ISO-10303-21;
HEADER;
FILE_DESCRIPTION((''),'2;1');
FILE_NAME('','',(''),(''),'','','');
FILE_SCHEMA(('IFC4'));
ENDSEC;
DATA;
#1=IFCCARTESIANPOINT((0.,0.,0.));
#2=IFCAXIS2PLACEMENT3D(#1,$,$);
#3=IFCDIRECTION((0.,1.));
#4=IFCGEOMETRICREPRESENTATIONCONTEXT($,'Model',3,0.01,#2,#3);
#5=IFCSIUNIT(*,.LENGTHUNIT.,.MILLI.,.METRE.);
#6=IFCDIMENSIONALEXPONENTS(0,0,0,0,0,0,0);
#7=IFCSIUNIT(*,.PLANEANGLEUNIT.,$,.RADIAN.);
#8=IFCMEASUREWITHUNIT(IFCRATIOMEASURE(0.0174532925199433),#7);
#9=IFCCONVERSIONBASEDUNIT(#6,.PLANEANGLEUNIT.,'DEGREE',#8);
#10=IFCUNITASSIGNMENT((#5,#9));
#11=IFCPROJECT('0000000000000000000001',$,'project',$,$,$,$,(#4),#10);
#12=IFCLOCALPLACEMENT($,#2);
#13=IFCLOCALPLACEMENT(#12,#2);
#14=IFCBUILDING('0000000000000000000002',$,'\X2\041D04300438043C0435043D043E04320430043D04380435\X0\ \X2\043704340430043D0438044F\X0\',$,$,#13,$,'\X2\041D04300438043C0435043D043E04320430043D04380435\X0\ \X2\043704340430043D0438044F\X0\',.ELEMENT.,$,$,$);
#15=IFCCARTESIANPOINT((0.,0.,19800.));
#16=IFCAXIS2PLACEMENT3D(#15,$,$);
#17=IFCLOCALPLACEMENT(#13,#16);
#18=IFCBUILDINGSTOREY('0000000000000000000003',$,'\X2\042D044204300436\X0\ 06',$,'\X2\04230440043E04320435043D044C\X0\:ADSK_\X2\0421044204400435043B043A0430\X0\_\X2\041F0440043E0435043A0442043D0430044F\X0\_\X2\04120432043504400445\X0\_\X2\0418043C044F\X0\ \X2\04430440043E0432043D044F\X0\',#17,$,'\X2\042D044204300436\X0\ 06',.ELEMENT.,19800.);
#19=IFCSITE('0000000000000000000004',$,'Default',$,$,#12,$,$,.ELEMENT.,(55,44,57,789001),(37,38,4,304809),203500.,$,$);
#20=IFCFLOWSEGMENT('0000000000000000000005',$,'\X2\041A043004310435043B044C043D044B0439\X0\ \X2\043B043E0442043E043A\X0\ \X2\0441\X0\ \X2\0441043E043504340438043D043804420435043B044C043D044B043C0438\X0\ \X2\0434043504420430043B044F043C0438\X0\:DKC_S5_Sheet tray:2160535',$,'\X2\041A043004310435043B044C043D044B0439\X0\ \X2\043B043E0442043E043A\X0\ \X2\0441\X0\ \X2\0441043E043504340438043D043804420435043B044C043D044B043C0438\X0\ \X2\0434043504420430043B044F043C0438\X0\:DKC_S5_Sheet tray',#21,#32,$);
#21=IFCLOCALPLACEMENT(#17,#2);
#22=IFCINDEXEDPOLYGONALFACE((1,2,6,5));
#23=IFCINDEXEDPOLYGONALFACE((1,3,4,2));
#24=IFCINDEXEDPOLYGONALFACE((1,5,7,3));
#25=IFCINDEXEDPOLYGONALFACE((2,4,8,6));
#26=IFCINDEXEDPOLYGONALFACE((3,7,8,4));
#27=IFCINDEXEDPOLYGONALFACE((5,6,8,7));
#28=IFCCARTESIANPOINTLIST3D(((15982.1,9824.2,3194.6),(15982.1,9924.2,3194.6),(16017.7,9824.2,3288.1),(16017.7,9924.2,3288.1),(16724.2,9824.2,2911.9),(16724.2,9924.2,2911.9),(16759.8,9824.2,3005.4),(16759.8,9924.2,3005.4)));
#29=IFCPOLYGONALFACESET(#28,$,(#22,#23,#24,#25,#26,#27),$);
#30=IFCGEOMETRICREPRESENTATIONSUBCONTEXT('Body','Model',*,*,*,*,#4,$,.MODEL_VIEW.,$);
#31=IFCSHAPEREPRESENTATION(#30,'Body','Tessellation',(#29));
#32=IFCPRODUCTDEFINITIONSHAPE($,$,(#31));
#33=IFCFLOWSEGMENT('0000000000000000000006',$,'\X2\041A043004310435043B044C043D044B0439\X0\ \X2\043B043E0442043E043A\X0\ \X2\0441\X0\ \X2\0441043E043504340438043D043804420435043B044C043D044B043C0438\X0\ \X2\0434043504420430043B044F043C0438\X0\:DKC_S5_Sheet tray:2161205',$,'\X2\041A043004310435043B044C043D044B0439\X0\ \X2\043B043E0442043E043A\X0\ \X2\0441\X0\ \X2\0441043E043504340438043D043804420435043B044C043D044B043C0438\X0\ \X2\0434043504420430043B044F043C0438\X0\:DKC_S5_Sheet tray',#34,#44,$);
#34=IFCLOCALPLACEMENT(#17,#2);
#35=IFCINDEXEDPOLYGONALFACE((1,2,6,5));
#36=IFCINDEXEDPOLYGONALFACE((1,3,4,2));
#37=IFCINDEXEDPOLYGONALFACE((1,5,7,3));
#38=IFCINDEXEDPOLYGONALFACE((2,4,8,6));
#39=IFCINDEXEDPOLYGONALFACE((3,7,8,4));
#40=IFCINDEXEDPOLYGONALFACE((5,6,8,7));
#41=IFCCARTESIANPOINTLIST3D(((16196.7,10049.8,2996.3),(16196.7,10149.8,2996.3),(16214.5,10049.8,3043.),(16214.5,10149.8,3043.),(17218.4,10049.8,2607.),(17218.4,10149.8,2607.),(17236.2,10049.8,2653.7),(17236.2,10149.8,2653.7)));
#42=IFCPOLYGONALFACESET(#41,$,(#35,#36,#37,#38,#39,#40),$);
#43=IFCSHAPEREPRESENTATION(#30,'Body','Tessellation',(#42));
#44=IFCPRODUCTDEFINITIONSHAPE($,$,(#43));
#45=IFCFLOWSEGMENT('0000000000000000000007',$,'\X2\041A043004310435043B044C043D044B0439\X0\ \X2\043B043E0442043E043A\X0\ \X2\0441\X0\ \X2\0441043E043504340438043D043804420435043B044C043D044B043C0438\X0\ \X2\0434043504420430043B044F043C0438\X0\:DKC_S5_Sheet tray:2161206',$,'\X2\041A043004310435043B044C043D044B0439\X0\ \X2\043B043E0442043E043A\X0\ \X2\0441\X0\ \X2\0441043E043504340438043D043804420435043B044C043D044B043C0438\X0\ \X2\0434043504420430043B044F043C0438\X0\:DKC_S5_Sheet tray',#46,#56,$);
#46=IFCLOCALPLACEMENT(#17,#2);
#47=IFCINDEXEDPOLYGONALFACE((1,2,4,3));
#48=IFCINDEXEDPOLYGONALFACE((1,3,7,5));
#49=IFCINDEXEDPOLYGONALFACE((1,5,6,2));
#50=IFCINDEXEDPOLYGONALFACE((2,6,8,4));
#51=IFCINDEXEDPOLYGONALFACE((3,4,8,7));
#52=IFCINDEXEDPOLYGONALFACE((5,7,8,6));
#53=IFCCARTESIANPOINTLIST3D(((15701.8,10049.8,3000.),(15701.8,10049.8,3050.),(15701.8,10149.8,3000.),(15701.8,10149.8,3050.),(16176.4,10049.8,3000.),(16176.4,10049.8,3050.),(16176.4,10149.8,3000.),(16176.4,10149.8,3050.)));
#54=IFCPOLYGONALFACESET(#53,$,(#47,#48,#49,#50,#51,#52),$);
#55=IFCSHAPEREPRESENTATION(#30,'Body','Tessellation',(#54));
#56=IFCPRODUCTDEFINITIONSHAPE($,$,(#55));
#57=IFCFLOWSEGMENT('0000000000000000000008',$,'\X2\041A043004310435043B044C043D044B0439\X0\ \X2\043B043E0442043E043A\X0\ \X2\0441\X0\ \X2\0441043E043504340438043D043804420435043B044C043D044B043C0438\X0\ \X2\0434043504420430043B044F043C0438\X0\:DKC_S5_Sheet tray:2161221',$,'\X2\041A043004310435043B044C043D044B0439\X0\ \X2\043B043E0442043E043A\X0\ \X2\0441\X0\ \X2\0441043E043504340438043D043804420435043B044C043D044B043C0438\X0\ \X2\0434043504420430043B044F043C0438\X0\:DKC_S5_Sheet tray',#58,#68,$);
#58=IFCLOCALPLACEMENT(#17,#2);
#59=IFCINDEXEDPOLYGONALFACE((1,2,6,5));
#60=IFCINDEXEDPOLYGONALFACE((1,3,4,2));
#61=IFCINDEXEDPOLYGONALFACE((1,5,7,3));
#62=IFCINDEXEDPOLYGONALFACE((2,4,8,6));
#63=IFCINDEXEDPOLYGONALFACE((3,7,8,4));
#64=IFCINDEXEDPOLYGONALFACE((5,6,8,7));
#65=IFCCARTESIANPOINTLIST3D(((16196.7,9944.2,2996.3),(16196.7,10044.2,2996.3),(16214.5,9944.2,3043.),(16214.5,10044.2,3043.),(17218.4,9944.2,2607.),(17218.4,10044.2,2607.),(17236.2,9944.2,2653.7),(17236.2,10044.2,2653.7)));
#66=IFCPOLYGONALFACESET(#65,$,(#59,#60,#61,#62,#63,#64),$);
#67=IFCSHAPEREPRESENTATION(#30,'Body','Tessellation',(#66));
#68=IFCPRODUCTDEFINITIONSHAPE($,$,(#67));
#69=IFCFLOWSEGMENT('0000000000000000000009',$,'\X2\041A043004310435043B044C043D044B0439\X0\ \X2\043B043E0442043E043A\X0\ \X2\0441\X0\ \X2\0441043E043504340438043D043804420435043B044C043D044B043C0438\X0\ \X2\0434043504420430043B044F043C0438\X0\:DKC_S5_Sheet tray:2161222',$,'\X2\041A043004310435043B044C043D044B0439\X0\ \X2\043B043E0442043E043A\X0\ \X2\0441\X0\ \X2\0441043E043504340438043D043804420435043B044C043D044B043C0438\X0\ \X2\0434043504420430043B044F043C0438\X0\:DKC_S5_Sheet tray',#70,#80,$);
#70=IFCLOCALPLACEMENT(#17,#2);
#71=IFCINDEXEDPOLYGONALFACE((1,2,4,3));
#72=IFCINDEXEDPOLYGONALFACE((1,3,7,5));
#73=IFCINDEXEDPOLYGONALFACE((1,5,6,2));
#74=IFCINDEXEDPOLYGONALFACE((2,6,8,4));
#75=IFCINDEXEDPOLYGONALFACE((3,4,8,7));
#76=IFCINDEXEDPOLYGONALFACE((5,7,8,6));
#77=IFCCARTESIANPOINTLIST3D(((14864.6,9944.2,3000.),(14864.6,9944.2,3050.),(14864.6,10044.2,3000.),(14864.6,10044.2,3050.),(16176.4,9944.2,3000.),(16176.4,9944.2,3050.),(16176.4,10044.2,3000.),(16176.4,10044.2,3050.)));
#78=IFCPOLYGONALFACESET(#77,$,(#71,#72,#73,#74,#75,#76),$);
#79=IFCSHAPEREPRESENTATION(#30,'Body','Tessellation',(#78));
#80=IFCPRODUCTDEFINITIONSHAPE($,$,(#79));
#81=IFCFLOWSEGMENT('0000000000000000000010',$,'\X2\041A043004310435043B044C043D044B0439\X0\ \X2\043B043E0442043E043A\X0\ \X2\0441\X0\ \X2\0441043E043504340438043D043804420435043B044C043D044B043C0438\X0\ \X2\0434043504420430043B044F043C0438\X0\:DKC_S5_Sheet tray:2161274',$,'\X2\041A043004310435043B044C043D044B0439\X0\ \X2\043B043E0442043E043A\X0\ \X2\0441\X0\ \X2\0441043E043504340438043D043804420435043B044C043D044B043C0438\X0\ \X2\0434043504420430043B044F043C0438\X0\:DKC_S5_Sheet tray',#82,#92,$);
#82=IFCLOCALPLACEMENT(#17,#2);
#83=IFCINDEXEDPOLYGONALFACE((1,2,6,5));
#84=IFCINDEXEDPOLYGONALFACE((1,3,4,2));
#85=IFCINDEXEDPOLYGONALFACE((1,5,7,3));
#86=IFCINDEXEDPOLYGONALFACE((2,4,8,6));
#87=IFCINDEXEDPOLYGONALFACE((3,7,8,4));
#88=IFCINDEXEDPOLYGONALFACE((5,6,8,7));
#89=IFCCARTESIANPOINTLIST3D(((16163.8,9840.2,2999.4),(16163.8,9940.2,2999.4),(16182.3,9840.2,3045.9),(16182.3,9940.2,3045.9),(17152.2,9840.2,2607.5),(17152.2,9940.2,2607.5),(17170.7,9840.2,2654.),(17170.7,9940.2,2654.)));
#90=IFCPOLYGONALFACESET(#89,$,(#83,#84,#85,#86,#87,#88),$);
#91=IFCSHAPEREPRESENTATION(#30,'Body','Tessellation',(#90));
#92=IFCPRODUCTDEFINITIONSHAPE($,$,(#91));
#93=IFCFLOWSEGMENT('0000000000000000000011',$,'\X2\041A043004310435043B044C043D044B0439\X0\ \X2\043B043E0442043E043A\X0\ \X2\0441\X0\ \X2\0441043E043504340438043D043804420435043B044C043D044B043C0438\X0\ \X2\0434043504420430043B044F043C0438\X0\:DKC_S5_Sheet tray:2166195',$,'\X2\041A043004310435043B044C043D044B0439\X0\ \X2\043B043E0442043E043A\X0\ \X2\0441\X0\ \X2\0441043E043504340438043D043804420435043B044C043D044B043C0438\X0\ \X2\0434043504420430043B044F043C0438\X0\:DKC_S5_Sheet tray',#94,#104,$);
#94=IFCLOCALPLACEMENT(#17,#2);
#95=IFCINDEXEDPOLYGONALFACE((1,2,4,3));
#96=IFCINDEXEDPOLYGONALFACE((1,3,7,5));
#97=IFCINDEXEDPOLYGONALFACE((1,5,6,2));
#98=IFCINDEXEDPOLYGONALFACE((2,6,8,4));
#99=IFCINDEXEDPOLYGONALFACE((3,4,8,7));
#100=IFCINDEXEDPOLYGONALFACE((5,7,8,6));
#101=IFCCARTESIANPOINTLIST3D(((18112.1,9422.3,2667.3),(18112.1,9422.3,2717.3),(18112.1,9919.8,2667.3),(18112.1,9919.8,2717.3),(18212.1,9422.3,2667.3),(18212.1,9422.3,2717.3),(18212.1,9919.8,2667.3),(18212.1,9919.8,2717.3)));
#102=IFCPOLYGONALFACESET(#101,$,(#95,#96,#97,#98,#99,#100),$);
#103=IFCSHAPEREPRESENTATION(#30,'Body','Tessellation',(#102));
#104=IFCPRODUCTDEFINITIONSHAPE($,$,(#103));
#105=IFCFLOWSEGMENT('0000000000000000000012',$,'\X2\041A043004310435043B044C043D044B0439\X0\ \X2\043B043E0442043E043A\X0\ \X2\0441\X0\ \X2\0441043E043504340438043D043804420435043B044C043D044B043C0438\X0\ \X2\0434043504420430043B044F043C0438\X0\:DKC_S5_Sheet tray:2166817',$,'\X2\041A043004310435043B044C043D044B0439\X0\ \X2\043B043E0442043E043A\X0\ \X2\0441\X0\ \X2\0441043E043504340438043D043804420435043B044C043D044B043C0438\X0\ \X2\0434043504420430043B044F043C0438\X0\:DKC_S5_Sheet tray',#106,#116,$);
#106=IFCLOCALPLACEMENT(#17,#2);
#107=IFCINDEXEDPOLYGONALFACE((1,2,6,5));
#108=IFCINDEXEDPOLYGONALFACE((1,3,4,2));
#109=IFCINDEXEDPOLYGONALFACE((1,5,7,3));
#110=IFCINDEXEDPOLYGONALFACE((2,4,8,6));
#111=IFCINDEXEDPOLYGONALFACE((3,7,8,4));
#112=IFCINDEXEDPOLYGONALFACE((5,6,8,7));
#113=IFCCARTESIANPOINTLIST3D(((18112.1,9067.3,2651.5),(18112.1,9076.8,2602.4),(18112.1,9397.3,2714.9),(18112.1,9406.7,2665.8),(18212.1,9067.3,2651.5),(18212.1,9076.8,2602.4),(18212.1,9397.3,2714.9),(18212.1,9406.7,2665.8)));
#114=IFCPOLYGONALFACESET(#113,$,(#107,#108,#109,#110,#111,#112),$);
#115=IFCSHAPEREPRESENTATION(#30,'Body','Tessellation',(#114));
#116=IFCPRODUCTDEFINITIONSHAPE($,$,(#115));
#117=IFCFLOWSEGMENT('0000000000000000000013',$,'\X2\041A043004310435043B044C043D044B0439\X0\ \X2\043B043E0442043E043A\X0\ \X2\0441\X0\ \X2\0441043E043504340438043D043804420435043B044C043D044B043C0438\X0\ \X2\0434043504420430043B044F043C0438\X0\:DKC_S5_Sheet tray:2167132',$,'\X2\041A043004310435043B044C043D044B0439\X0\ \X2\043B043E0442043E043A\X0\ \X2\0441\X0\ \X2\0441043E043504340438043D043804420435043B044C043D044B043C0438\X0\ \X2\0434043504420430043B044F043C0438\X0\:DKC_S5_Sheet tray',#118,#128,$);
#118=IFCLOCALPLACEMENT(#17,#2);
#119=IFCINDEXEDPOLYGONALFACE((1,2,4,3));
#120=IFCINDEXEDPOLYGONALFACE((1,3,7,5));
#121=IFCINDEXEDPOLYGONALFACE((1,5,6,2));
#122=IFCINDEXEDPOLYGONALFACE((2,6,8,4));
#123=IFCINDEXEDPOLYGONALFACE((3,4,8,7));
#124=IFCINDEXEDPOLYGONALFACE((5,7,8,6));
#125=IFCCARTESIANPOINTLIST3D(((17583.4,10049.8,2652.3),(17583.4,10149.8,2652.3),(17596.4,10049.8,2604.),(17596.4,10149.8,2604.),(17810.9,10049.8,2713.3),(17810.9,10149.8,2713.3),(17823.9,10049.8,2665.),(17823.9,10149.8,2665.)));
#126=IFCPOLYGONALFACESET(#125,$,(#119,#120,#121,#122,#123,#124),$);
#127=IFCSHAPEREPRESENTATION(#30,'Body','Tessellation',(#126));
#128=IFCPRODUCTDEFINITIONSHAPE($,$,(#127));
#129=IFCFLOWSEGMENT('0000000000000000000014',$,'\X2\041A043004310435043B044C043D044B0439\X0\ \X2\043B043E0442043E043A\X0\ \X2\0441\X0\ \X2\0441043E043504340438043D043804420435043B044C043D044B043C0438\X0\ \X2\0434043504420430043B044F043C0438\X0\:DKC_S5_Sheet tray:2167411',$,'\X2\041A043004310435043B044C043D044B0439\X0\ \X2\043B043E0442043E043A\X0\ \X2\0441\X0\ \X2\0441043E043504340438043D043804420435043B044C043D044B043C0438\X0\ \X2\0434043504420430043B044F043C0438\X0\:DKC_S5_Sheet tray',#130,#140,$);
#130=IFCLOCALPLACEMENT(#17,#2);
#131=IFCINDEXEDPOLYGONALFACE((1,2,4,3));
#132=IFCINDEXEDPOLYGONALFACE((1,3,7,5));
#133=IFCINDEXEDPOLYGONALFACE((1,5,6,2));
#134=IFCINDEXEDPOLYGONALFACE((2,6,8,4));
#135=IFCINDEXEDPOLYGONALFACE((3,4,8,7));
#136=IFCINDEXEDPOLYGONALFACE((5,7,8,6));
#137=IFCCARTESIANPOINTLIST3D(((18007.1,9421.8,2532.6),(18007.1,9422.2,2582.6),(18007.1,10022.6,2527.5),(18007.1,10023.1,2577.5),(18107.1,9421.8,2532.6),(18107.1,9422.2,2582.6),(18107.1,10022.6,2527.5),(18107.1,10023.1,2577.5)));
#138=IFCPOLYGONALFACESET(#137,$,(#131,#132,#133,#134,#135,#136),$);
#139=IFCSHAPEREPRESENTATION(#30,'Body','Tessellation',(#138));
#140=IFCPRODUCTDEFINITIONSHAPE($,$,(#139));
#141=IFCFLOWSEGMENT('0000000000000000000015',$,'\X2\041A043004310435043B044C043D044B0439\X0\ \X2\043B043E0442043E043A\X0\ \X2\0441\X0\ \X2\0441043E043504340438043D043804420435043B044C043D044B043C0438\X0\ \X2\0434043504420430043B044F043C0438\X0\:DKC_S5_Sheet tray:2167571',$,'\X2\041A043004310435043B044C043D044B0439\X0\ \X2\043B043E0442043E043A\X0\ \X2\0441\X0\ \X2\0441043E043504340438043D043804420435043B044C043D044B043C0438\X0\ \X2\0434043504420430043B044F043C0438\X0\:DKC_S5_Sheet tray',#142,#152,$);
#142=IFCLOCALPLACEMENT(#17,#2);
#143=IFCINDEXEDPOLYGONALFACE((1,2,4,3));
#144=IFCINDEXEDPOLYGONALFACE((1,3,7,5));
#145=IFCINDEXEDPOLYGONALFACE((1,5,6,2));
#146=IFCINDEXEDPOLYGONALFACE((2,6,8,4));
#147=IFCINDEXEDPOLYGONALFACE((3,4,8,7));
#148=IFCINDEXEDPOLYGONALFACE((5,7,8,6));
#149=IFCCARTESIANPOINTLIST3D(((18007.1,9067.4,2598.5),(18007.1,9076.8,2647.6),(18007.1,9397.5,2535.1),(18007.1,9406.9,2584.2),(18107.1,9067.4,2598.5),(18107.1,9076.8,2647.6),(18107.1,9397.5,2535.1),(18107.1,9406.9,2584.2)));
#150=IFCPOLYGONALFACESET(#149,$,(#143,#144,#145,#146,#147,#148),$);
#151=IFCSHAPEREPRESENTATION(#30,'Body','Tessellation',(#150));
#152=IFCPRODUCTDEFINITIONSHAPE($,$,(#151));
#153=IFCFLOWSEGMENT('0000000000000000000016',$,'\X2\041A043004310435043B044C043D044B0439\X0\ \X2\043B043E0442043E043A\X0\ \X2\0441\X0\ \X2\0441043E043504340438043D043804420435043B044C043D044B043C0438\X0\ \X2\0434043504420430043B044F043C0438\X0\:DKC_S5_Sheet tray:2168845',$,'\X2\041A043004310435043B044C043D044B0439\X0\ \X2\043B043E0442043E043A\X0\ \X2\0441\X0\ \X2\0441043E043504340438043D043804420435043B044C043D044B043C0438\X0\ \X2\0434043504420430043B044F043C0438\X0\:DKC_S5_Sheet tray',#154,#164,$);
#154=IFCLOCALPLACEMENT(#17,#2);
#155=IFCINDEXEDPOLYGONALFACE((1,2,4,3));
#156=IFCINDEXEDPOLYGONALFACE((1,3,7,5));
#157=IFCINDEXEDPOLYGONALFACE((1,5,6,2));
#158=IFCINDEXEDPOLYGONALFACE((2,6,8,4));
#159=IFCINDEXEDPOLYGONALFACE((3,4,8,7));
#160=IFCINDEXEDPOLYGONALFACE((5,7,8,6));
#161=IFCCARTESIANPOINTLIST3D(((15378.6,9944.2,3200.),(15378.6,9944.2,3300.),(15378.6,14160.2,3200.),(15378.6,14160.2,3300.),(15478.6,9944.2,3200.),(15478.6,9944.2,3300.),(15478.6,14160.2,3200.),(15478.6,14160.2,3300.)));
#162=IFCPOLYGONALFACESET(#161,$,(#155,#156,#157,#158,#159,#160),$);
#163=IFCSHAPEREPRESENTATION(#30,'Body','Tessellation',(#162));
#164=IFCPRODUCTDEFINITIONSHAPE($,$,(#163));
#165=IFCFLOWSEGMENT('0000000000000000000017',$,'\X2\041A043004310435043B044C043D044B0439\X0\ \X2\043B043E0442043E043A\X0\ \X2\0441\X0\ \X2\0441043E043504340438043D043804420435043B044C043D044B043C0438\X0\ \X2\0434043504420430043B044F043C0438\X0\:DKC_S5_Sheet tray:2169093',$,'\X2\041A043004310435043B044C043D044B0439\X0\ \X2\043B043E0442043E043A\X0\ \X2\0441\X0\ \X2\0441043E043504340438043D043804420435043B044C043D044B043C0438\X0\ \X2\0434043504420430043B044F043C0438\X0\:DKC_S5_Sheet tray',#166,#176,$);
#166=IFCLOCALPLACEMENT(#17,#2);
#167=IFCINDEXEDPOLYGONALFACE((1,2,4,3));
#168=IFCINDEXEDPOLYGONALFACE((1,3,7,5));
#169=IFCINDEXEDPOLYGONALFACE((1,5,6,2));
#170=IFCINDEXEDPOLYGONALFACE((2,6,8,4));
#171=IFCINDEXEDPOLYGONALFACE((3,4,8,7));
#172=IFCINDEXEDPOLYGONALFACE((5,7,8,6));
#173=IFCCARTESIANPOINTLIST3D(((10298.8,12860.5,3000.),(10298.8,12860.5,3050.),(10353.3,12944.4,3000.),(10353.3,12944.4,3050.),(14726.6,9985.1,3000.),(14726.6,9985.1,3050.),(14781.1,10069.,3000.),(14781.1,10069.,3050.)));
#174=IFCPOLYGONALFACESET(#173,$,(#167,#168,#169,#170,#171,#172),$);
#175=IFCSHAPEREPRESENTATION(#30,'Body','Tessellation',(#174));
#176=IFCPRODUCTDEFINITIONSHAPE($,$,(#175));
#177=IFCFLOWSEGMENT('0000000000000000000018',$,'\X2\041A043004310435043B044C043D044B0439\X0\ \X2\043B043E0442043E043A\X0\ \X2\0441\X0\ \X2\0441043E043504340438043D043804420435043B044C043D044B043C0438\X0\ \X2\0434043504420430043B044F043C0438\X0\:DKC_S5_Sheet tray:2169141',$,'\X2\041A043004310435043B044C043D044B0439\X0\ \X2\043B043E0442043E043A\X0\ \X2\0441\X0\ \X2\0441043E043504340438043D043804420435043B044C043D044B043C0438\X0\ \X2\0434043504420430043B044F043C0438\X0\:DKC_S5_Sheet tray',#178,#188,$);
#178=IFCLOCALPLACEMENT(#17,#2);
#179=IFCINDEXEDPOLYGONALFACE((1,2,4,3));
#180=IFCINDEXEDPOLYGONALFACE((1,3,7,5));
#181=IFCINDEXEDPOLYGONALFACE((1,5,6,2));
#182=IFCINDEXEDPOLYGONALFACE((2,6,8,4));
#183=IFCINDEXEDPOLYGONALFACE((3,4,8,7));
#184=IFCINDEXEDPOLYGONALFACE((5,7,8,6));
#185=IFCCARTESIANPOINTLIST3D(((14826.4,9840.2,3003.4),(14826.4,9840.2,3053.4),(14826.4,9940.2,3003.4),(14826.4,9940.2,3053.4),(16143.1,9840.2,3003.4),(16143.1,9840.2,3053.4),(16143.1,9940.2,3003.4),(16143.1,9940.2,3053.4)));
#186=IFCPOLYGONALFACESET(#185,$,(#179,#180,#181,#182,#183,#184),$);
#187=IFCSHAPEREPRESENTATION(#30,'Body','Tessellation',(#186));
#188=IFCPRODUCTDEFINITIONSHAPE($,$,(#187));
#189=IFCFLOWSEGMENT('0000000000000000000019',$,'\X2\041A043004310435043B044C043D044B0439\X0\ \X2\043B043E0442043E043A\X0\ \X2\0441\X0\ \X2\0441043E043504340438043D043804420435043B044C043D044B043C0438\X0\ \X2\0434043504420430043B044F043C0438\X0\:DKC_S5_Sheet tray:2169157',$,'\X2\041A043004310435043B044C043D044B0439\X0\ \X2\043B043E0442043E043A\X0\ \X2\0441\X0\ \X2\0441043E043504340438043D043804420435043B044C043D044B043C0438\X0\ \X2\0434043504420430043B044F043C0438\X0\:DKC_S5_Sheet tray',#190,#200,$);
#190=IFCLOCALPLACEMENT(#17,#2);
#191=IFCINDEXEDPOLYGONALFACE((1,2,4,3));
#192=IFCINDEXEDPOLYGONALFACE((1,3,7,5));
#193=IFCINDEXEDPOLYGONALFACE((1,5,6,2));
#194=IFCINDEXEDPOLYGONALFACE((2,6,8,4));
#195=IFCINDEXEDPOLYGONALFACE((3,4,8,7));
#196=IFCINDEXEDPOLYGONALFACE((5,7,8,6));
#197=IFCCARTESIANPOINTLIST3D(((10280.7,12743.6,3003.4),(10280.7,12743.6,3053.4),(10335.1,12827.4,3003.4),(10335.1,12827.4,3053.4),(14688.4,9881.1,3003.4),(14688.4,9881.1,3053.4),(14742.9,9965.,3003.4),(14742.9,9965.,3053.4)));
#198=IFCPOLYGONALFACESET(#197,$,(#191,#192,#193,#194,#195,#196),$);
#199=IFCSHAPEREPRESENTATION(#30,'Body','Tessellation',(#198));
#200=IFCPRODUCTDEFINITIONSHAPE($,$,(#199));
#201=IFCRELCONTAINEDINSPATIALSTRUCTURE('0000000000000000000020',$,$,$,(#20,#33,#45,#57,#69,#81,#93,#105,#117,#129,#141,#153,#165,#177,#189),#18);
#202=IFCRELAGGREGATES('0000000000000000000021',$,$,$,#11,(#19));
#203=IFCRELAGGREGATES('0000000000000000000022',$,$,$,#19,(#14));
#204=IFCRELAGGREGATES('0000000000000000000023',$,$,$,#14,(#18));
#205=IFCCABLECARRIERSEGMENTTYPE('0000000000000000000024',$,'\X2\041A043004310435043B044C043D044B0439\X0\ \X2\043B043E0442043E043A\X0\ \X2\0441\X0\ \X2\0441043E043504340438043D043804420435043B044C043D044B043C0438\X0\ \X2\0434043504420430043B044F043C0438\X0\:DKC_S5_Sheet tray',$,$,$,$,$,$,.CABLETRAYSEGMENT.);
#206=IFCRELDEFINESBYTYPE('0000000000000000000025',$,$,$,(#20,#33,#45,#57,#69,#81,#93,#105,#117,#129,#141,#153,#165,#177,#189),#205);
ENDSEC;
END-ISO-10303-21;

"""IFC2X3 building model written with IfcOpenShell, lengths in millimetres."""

from ifc_helpers import new_model, entity, si_unit, converted_unit, direction, frame, frame_2d, origin, origin_2d_with_axis, place, context, subcontext, project, spatial, rectangle, extrude, type_object, element, save


model = new_model("IFC2X3")

# Units and contexts
model_context = context("Model", 3, precision=0.01, world=origin(), true_north=direction((0.0, 1.0)))
body_context = subcontext(model_context, "Body", "Model", "MODEL_VIEW")
ifc_project = project(units=[si_unit("LENGTHUNIT", "METRE", prefix="MILLI"), converted_unit("PLANEANGLEUNIT", "DEGREE", entity("IfcRatioMeasure", 0.0174532925199433), si_unit("PLANEANGLEUNIT", "RADIAN"), dimensions=[0, 0, 0, 0, 0, 0, 0])], contexts=[model_context])

# Site, building, storey
site_placement = place(None, origin())
site = spatial("IfcSite", under=ifc_project, at=site_placement, Name="Default", CompositionType="ELEMENT", RefLatitude=(55, 44, 57, 789001), RefLongitude=(37, 38, 4, 304809), RefElevation=203500.0)
building_placement = place(site_placement, origin())
building = spatial("IfcBuilding", under=site, at=building_placement, Name="Наименование здания", LongName="Наименование здания", CompositionType="ELEMENT")
storey_placement = place(building_placement, frame((0.0, 0.0, 19800.0)))
storey = spatial("IfcBuildingStorey", under=building, at=storey_placement, Name="Этаж 06", ObjectType="Уровень:ADSK_Стрелка_Проектная_Вверх_Имя уровня", LongName="Этаж 06", CompositionType="ELEMENT", Elevation=19800.0)

# Flow segments
cable_carrier_segment_type = type_object("IfcCableCarrierSegmentType", Name="Кабельный лоток с соединительными деталями:DKC_S5_Sheet tray", PredefinedType="CABLETRAYSEGMENT")
flow_segment_1_placement = place(storey_placement, frame((15982.1, 9824.2, 2911.9)))
element("IfcFlowSegment", 1, at=flow_segment_1_placement, inside=storey, type_object=cable_carrier_segment_type, Name="Кабельный лоток с соединительными деталями:DKC_S5_Sheet tray:2160535", ObjectType="Кабельный лоток с соединительными деталями:DKC_S5_Sheet tray", context=body_context, shape_type="SweptSolid", body=[
    extrude(rectangle(XDim=100.0, YDim=100.0, at=origin_2d_with_axis()), frame((17.8, 50.0, 329.4), z_axis=(0.934483, 0.0, -0.356007), x_axis=(0.356007, 0.0, 0.934483)), (0.0, 0.0, 1.0), 794.0),
])
flow_segment_2_placement = place(storey_placement, frame((16196.7, 10049.8, 2607.0)))
element("IfcFlowSegment", 2, at=flow_segment_2_placement, inside=storey, type_object=cable_carrier_segment_type, Name="Кабельный лоток с соединительными деталями:DKC_S5_Sheet tray:2161205", ObjectType="Кабельный лоток с соединительными деталями:DKC_S5_Sheet tray", context=body_context, shape_type="SweptSolid", body=[
    extrude(rectangle(XDim=50.0, YDim=100.0, at=origin_2d_with_axis()), frame((8.9, 50.0, 412.6), z_axis=(0.934483, 0.0, -0.356007), x_axis=(0.356007, 0.0, 0.934483)), (0.0, 0.0, 1.0), 1093.3),
])
flow_segment_3_placement = place(storey_placement, frame((15701.8, 10049.8, 3000.0)))
element("IfcFlowSegment", 3, at=flow_segment_3_placement, inside=storey, type_object=cable_carrier_segment_type, Name="Кабельный лоток с соединительными деталями:DKC_S5_Sheet tray:2161206", ObjectType="Кабельный лоток с соединительными деталями:DKC_S5_Sheet tray", context=body_context, shape_type="SweptSolid", body=[
    extrude(rectangle(XDim=474.6, YDim=100.0, at=origin_2d_with_axis()), frame((237.3, 50.0, 0.0), z_axis=(0.0, 0.0, 1.0), x_axis=(-1.0, 0.0, 0.0)), (0.0, 0.0, 1.0), 50.0),
])
flow_segment_4_placement = place(storey_placement, frame((16196.7, 9944.2, 2607.0)))
element("IfcFlowSegment", 4, at=flow_segment_4_placement, inside=storey, type_object=cable_carrier_segment_type, Name="Кабельный лоток с соединительными деталями:DKC_S5_Sheet tray:2161221", ObjectType="Кабельный лоток с соединительными деталями:DKC_S5_Sheet tray", context=body_context, shape_type="SweptSolid", body=[
    extrude(rectangle(XDim=50.0, YDim=100.0, at=origin_2d_with_axis()), frame((8.9, 50.0, 412.6), z_axis=(0.934483, 0.0, -0.356007), x_axis=(0.356007, 0.0, 0.934483)), (0.0, 0.0, 1.0), 1093.3),
])
flow_segment_5_placement = place(storey_placement, frame((14864.6, 9944.2, 3000.0)))
element("IfcFlowSegment", 5, at=flow_segment_5_placement, inside=storey, type_object=cable_carrier_segment_type, Name="Кабельный лоток с соединительными деталями:DKC_S5_Sheet tray:2161222", ObjectType="Кабельный лоток с соединительными деталями:DKC_S5_Sheet tray", context=body_context, shape_type="SweptSolid", body=[
    extrude(rectangle(XDim=1311.8, YDim=100.0, at=origin_2d_with_axis()), frame((655.9, 50.0, 0.0), z_axis=(0.0, 0.0, 1.0), x_axis=(-1.0, 0.0, 0.0)), (0.0, 0.0, 1.0), 50.0),
])
flow_segment_6_placement = place(storey_placement, frame((16163.8, 9840.2, 2607.5)))
element("IfcFlowSegment", 6, at=flow_segment_6_placement, inside=storey, type_object=cable_carrier_segment_type, Name="Кабельный лоток с соединительными деталями:DKC_S5_Sheet tray:2161274", ObjectType="Кабельный лоток с соединительными деталями:DKC_S5_Sheet tray", context=body_context, shape_type="SweptSolid", body=[
    extrude(rectangle(XDim=50.0, YDim=100.0, at=origin_2d_with_axis()), frame((9.2, 50.0, 415.2), z_axis=(0.929574, 0.0, -0.368637), x_axis=(0.368637, 0.0, 0.929574)), (0.0, 0.0, 1.0), 1063.3),
])
flow_segment_7_placement = place(storey_placement, frame((18112.1, 9422.3, 2667.3)))
element("IfcFlowSegment", 7, at=flow_segment_7_placement, inside=storey, type_object=cable_carrier_segment_type, Name="Кабельный лоток с соединительными деталями:DKC_S5_Sheet tray:2166195", ObjectType="Кабельный лоток с соединительными деталями:DKC_S5_Sheet tray", context=body_context, shape_type="SweptSolid", body=[
    extrude(rectangle(XDim=497.6, YDim=100.0, at=origin_2d_with_axis()), frame((50.0, 248.8, 0.0), z_axis=(0.0, 0.0, 1.0), x_axis=(0.0, -1.0, 0.0)), (0.0, 0.0, 1.0), 50.0),
])
flow_segment_8_placement = place(storey_placement, frame((18112.1, 9067.4, 2602.4)))
element("IfcFlowSegment", 8, at=flow_segment_8_placement, inside=storey, type_object=cable_carrier_segment_type, Name="Кабельный лоток с соединительными деталями:DKC_S5_Sheet tray:2166817", ObjectType="Кабельный лоток с соединительными деталями:DKC_S5_Sheet tray", context=body_context, shape_type="SweptSolid", body=[
    extrude(rectangle(XDim=50.0, YDim=335.9, at=frame_2d((0.0, 0.0), x_axis=(0.0, 1.0))), frame((0.0, 169.7, 56.3), z_axis=(1.0, 0.0, 0.0), x_axis=(0.0, 0.982015, 0.188801)), (0.0, 0.0, 1.0), 100.0),
])
flow_segment_9_placement = place(storey_placement, frame((17583.4, 10049.8, 2604.0)))
element("IfcFlowSegment", 9, at=flow_segment_9_placement, inside=storey, type_object=cable_carrier_segment_type, Name="Кабельный лоток с соединительными деталями:DKC_S5_Sheet tray:2167132", ObjectType="Кабельный лоток с соединительными деталями:DKC_S5_Sheet tray", context=body_context, shape_type="SweptSolid", body=[
    extrude(rectangle(XDim=50.0, YDim=100.0, at=frame_2d((0.0, 0.0), x_axis=(0.0, 1.0))), frame((6.5, 50.0, 24.1), z_axis=(0.965926, 0.0, 0.258819), x_axis=(0.0, 1.0, 0.0)), (0.0, 0.0, 1.0), 235.5),
])
flow_segment_10_placement = place(storey_placement, frame((18007.1, 9421.8, 2527.5)))
element("IfcFlowSegment", 10, at=flow_segment_10_placement, inside=storey, type_object=cable_carrier_segment_type, Name="Кабельный лоток с соединительными деталями:DKC_S5_Sheet tray:2167411", ObjectType="Кабельный лоток с соединительными деталями:DKC_S5_Sheet tray", context=body_context, shape_type="SweptSolid", body=[
    extrude(rectangle(XDim=50.0, YDim=600.8, at=frame_2d((0.0, 0.0), x_axis=(0.0, 1.0))), frame((0.0, 300.6, 27.5), z_axis=(1.0, 0.0, 0.0), x_axis=(0.0, -0.999964, 0.008474)), (0.0, 0.0, 1.0), 100.0),
])
flow_segment_11_placement = place(storey_placement, frame((18007.1, 9067.4, 2535.1)))
element("IfcFlowSegment", 11, at=flow_segment_11_placement, inside=storey, type_object=cable_carrier_segment_type, Name="Кабельный лоток с соединительными деталями:DKC_S5_Sheet tray:2167571", ObjectType="Кабельный лоток с соединительными деталями:DKC_S5_Sheet tray", context=body_context, shape_type="SweptSolid", body=[
    extrude(rectangle(XDim=50.0, YDim=336.2, at=frame_2d((0.0, 0.0), x_axis=(0.0, 1.0))), frame((0.0, 169.8, 56.3), z_axis=(1.0, 0.0, 0.0), x_axis=(0.0, 0.982015, -0.188801)), (0.0, 0.0, 1.0), 100.0),
])
flow_segment_12_placement = place(storey_placement, frame((15378.6, 9944.2, 3200.0)))
element("IfcFlowSegment", 12, at=flow_segment_12_placement, inside=storey, type_object=cable_carrier_segment_type, Name="Кабельный лоток с соединительными деталями:DKC_S5_Sheet tray:2168845", ObjectType="Кабельный лоток с соединительными деталями:DKC_S5_Sheet tray", context=body_context, shape_type="SweptSolid", body=[
    extrude(rectangle(XDim=4216.0, YDim=100.0, at=origin_2d_with_axis()), frame((50.0, 2108.0, 0.0), z_axis=(0.0, 0.0, 1.0), x_axis=(0.0, 1.0, 0.0)), (0.0, 0.0, 1.0), 100.0),
])
flow_segment_13_placement = place(storey_placement, frame((10298.8, 9985.1, 3000.0)))
element("IfcFlowSegment", 13, at=flow_segment_13_placement, inside=storey, type_object=cable_carrier_segment_type, Name="Кабельный лоток с соединительными деталями:DKC_S5_Sheet tray:2169093", ObjectType="Кабельный лоток с соединительными деталями:DKC_S5_Sheet tray", context=body_context, shape_type="SweptSolid", body=[
    extrude(rectangle(XDim=5279.5, YDim=100.0, at=origin_2d_with_axis()), frame((2241.1, 1479.7, 0.0), z_axis=(0.0, 0.0, 1.0), x_axis=(-0.838671, 0.544639, 0.0)), (0.0, 0.0, 1.0), 50.0),
])
flow_segment_14_placement = place(storey_placement, frame((14826.5, 9840.2, 3003.4)))
element("IfcFlowSegment", 14, at=flow_segment_14_placement, inside=storey, type_object=cable_carrier_segment_type, Name="Кабельный лоток с соединительными деталями:DKC_S5_Sheet tray:2169141", ObjectType="Кабельный лоток с соединительными деталями:DKC_S5_Sheet tray", context=body_context, shape_type="SweptSolid", body=[
    extrude(rectangle(XDim=1316.7, YDim=100.0, at=origin_2d_with_axis()), frame((658.3, 50.0, 0.0), z_axis=(0.0, 0.0, 1.0), x_axis=(-1.0, 0.0, 0.0)), (0.0, 0.0, 1.0), 50.0),
])
flow_segment_15_placement = place(storey_placement, frame((10280.6, 9881.1, 3003.4)))
element("IfcFlowSegment", 15, at=flow_segment_15_placement, inside=storey, type_object=cable_carrier_segment_type, Name="Кабельный лоток с соединительными деталями:DKC_S5_Sheet tray:2169157", ObjectType="Кабельный лоток с соединительными деталями:DKC_S5_Sheet tray", context=body_context, shape_type="SweptSolid", body=[
    extrude(rectangle(XDim=5255.7, YDim=100.0, at=origin_2d_with_axis()), frame((2231.1, 1473.2, 0.0), z_axis=(0.0, 0.0, 1.0), x_axis=(-0.838671, 0.544639, 0.0)), (0.0, 0.0, 1.0), 50.0),
])

save(model, "model.ifc")
